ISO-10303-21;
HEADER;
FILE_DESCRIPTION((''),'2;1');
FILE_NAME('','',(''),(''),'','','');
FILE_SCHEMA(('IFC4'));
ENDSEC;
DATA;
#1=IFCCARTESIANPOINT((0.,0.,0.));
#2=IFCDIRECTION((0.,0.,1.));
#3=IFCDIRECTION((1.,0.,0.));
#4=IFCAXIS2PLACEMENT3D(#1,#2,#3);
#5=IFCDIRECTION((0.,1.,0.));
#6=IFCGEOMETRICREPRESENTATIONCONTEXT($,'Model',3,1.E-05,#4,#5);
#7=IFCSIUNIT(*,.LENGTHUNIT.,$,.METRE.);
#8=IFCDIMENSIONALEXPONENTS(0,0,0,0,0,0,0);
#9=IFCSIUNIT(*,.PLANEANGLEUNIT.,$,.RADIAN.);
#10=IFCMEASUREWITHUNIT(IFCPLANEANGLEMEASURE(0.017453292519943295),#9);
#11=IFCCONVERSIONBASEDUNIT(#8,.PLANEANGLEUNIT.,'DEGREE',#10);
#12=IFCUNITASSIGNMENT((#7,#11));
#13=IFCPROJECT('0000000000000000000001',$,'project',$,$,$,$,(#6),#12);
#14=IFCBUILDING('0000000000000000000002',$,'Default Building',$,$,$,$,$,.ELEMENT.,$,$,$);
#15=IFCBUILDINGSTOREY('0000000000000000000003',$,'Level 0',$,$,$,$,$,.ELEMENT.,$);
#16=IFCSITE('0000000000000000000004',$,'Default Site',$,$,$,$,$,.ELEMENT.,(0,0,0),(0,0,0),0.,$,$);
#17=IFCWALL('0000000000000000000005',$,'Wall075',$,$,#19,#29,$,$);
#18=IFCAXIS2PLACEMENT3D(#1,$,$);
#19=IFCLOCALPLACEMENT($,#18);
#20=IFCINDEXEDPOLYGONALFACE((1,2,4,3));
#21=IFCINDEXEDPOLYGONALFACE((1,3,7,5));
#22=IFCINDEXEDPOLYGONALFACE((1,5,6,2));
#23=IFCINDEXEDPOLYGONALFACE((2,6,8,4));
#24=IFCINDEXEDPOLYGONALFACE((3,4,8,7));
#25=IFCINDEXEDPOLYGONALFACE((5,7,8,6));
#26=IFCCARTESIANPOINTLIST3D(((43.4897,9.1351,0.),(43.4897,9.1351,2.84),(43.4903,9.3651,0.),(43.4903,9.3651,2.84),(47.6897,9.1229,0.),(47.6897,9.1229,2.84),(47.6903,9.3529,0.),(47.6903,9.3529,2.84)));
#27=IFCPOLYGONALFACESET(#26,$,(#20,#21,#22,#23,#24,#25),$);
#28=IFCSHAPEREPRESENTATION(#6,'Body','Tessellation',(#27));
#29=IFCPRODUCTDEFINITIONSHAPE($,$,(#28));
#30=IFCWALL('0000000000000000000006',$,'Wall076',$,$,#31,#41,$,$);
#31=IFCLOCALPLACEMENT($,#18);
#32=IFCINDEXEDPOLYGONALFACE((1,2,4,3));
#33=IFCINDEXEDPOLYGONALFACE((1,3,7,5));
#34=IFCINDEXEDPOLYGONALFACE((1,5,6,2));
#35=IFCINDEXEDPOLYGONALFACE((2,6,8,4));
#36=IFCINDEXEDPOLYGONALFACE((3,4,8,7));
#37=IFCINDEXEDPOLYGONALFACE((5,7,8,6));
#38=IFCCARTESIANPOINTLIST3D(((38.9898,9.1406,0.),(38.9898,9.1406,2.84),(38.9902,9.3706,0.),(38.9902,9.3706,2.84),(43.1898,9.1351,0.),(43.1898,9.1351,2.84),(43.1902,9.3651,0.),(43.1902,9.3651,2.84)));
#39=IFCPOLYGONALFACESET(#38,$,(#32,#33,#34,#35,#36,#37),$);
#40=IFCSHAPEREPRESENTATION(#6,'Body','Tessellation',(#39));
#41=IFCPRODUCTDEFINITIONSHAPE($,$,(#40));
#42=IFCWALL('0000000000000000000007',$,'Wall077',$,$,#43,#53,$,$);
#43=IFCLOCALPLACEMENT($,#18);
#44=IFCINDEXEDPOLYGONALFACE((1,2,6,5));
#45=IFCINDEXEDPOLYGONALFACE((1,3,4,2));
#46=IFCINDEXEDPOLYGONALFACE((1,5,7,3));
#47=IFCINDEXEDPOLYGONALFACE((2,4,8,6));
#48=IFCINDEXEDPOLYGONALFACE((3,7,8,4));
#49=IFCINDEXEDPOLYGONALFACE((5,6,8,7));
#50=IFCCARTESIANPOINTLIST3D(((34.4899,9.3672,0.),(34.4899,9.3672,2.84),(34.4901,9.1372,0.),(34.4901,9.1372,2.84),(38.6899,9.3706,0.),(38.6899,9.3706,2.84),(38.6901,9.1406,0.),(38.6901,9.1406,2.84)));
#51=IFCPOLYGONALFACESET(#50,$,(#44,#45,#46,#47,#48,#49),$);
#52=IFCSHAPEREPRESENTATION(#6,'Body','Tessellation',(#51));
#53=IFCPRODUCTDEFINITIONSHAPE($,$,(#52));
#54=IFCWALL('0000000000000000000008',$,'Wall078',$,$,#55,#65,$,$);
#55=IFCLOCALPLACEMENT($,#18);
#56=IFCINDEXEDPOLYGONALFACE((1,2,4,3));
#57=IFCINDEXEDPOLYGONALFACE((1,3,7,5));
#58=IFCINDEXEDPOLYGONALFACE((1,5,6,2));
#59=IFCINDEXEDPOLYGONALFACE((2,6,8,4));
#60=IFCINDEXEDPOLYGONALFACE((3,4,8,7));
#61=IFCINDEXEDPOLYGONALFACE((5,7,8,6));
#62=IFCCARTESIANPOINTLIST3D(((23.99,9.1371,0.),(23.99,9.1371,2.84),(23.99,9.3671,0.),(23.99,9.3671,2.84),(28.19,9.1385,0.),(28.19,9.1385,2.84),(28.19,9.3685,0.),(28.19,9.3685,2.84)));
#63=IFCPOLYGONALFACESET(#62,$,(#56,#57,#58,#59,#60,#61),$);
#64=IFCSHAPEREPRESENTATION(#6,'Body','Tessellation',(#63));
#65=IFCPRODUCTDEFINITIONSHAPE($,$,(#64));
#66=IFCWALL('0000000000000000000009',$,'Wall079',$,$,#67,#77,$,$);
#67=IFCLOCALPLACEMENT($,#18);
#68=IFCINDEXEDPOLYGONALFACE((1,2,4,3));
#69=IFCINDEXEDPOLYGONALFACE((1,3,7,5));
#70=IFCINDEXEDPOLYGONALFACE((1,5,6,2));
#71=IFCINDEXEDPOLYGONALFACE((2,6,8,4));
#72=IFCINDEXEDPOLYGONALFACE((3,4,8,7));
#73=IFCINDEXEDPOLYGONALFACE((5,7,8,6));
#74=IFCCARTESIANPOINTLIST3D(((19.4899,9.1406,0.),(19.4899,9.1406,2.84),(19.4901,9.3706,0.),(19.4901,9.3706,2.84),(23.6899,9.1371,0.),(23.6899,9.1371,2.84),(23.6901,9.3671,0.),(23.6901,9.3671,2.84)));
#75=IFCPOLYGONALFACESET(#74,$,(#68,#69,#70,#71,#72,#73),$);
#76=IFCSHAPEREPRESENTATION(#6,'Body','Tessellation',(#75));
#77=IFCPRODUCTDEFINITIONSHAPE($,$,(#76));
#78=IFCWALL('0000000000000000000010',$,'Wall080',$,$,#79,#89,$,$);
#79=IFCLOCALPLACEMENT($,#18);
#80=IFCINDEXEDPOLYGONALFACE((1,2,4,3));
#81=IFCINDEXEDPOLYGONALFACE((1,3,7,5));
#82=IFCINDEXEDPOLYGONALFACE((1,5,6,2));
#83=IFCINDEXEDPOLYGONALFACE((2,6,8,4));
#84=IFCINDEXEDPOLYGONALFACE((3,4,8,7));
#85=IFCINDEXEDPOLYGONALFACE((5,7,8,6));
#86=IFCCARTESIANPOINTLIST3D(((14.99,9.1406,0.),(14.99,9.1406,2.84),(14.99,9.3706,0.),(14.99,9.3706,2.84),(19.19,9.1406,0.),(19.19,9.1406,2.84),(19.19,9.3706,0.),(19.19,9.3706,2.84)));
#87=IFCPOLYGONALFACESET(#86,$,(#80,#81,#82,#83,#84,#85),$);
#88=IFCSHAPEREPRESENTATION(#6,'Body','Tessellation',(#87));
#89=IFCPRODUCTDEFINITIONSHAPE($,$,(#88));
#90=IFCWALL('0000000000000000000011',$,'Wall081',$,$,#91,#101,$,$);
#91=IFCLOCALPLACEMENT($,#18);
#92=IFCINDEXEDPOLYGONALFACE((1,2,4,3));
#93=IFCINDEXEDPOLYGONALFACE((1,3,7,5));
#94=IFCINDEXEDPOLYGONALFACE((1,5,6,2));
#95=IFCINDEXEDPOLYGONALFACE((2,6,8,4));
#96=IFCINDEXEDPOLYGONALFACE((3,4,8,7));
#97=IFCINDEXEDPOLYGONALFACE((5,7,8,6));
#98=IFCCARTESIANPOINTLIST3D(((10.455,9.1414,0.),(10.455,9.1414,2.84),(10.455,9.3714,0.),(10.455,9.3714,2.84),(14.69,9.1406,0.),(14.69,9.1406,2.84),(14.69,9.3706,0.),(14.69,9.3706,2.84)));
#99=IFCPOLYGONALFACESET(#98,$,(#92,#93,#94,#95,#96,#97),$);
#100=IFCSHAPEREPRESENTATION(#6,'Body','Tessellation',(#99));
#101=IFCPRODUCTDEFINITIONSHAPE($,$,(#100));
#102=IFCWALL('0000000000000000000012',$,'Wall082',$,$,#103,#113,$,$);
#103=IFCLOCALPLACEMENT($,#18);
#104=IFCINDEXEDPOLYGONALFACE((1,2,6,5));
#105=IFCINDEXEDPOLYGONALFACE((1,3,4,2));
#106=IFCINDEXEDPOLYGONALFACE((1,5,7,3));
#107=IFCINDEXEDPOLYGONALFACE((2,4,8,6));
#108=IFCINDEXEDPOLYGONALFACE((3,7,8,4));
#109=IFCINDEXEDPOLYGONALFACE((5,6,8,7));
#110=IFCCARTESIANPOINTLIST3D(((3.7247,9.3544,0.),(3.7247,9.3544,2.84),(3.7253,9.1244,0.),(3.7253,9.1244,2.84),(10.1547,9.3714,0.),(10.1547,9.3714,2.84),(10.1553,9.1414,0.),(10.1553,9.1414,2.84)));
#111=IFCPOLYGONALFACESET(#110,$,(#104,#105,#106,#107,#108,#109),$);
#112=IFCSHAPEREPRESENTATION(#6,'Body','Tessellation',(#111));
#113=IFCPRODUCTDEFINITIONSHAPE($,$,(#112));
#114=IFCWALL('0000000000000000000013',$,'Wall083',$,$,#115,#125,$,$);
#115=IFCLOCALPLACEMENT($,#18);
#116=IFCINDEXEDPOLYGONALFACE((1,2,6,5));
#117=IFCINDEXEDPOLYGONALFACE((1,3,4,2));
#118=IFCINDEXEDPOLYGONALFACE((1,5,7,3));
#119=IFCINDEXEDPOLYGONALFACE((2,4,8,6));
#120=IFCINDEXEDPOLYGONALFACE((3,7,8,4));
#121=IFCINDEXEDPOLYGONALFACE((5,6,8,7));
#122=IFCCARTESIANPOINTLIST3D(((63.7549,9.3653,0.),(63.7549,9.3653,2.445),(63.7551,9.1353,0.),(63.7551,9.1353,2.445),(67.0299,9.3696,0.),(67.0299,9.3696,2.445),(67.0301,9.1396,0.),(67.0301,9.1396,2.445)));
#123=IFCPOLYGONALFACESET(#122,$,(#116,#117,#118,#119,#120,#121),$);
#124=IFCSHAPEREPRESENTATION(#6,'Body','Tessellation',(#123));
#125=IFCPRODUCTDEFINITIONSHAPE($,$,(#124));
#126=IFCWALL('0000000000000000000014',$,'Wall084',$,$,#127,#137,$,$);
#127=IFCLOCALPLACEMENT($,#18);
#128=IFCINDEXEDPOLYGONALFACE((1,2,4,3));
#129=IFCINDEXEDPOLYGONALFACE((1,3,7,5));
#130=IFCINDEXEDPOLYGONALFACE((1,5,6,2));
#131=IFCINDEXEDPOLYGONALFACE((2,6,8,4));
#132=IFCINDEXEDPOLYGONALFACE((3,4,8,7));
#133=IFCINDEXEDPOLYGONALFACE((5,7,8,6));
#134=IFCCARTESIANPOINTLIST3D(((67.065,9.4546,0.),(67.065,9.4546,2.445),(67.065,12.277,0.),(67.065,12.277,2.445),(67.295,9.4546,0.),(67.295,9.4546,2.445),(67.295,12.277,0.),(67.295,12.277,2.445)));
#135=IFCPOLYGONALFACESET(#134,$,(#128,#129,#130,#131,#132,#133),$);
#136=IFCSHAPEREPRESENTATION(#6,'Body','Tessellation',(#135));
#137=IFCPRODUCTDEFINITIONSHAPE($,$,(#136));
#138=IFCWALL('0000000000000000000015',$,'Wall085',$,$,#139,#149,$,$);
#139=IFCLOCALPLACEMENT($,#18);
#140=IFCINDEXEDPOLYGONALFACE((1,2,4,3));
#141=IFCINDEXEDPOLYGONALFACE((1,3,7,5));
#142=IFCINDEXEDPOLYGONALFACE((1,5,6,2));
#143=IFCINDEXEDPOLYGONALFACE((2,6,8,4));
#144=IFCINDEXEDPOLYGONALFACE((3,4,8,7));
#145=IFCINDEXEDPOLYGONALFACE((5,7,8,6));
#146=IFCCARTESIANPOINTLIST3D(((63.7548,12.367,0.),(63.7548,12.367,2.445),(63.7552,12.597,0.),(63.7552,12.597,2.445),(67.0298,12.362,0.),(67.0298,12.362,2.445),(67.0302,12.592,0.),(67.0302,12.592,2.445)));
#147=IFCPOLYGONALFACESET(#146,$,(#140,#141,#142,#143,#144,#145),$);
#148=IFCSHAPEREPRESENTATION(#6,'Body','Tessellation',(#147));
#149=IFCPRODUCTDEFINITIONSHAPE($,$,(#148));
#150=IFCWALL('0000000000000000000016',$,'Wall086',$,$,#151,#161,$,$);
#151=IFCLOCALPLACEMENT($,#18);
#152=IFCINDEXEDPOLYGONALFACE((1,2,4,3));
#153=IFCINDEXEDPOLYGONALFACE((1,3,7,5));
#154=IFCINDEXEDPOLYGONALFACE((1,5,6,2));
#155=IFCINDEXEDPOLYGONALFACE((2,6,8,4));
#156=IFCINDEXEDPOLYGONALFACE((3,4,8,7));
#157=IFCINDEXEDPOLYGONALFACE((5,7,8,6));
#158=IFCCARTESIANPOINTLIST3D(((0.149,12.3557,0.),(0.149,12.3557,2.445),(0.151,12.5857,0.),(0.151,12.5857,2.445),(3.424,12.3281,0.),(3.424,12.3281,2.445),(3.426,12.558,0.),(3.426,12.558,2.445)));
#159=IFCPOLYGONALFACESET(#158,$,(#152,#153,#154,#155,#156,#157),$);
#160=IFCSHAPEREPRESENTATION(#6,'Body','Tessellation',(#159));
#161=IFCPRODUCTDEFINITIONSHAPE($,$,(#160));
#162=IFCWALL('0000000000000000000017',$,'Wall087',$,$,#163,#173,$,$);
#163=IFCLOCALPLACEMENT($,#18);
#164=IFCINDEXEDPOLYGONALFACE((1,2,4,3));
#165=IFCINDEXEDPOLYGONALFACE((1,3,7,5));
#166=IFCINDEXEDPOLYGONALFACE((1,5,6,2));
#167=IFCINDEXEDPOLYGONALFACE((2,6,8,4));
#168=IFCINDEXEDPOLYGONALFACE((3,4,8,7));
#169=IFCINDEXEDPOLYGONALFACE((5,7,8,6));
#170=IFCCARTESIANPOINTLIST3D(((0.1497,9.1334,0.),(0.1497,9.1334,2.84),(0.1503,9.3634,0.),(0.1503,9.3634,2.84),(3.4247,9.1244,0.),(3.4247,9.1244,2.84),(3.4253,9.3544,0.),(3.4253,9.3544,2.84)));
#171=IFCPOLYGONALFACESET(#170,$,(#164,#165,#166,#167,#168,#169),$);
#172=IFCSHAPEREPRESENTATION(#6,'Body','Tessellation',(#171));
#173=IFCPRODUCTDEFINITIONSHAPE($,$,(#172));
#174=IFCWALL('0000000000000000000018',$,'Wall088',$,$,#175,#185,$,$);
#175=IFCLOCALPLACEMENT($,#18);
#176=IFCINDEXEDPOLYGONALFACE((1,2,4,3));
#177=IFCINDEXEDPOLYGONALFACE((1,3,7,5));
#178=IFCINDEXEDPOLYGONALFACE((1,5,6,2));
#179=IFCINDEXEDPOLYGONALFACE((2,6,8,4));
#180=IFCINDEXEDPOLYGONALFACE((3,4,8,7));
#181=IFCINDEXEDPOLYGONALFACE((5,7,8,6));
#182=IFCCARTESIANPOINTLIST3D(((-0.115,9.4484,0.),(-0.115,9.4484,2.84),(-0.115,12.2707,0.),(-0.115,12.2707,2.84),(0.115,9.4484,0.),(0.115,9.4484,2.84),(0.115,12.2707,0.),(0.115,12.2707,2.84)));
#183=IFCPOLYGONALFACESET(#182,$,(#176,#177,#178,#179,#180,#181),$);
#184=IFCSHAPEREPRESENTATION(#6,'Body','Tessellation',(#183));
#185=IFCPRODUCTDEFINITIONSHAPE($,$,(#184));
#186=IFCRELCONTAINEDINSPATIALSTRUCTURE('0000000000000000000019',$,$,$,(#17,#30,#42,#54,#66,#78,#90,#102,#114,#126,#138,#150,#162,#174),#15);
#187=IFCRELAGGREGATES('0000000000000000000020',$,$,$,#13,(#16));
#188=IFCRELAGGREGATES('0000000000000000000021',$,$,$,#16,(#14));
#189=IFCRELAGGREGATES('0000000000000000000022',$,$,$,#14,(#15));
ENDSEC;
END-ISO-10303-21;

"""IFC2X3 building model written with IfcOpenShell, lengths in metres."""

from ifc_helpers import new_model, entity, si_unit, converted_unit, direction, frame, frame_2d, origin_with_axes, place, context, project, spatial, rectangle, extrude, element, save


model = new_model("IFC2X3")

# Units and contexts
model_context = context("Model", 3, precision=1e-05, world=origin_with_axes(), true_north=direction((0.0, 1.0, 0.0)))
ifc_project = project(units=[si_unit("LENGTHUNIT", "METRE"), converted_unit("PLANEANGLEUNIT", "DEGREE", entity("IfcPlaneAngleMeasure", 0.017453292519943295), si_unit("PLANEANGLEUNIT", "RADIAN"), dimensions=[0, 0, 0, 0, 0, 0, 0])], contexts=[model_context])

# Site, building, storey
site = spatial("IfcSite", under=ifc_project, Name="Default Site", CompositionType="ELEMENT", RefLatitude=(0, 0, 0), RefLongitude=(0, 0, 0), RefElevation=0.0)
building = spatial("IfcBuilding", under=site, Name="Default Building", CompositionType="ELEMENT")
storey = spatial("IfcBuildingStorey", under=building, Name="Level 0", CompositionType="ELEMENT")

# Walls
placement = place(None, origin_with_axes())
element("IfcWall", 1, at=placement, inside=storey, Name="Wall075", context=model_context, shape_type="SweptSolid", body=[
    extrude(rectangle(XDim=4.2, YDim=0.23, at=frame_2d((0.0, 0.0), x_axis=(0.999996, -0.002895, 0.0))), frame((45.59, 9.244, 0.0), z_axis=(0.0, 0.0, 1.0), x_axis=(1.0, 0.0, 0.0)), (0.0, 0.0, 1.0), 2.84),
])
element("IfcWall", 2, at=placement, inside=storey, Name="Wall076", context=model_context, shape_type="SweptSolid", body=[
    extrude(rectangle(XDim=4.2, YDim=0.23, at=frame_2d((0.0, 0.0), x_axis=(-0.999999, 0.001314, 0.0))), frame((41.09, 9.2528, 0.0), z_axis=(0.0, 0.0, 1.0), x_axis=(1.0, 0.0, 0.0)), (0.0, 0.0, 1.0), 2.84),
])
element("IfcWall", 3, at=placement, inside=storey, Name="Wall077", context=model_context, shape_type="SweptSolid", body=[
    extrude(rectangle(XDim=4.2, YDim=0.23, at=frame_2d((0.0, 0.0), x_axis=(1.0, 0.000801, 0.0))), frame((36.59, 9.2539, 0.0), z_axis=(0.0, 0.0, 1.0), x_axis=(1.0, 0.0, 0.0)), (0.0, 0.0, 1.0), 2.84),
])
element("IfcWall", 4, at=placement, inside=storey, Name="Wall078", context=model_context, shape_type="SweptSolid", body=[
    extrude(rectangle(XDim=4.2, YDim=0.23, at=frame_2d((0.0, 0.0), x_axis=(-1.0, -0.000329, 0.0))), frame((26.09, 9.2528, 0.0), z_axis=(0.0, 0.0, 1.0), x_axis=(1.0, 0.0, 0.0)), (0.0, 0.0, 1.0), 2.84),
])
element("IfcWall", 5, at=placement, inside=storey, Name="Wall079", context=model_context, shape_type="SweptSolid", body=[
    extrude(rectangle(XDim=4.2, YDim=0.23, at=frame_2d((0.0, 0.0), x_axis=(-1.0, 0.000835, 0.0))), frame((21.59, 9.2539, 0.0), z_axis=(0.0, 0.0, 1.0), x_axis=(1.0, 0.0, 0.0)), (0.0, 0.0, 1.0), 2.84),
])
element("IfcWall", 6, at=placement, inside=storey, Name="Wall080", context=model_context, shape_type="SweptSolid", body=[
    extrude(rectangle(XDim=4.2, YDim=0.23, at=frame_2d((0.0, 0.0), x_axis=(-1.0, -0.000014, 0.0))), frame((17.09, 9.2556, 0.0), z_axis=(0.0, 0.0, 1.0), x_axis=(1.0, 0.0, 0.0)), (0.0, 0.0, 1.0), 2.84),
])
element("IfcWall", 7, at=placement, inside=storey, Name="Wall081", context=model_context, shape_type="SweptSolid", body=[
    extrude(rectangle(XDim=4.235, YDim=0.23, at=frame_2d((0.0, 0.0), x_axis=(1.0, -0.000195, 0.0))), frame((12.5725, 9.256, 0.0), z_axis=(0.0, 0.0, 1.0), x_axis=(1.0, 0.0, 0.0)), (0.0, 0.0, 1.0), 2.84),
])
element("IfcWall", 8, at=placement, inside=storey, Name="Wall082", context=model_context, shape_type="SweptSolid", body=[
    extrude(rectangle(XDim=6.43, YDim=0.23, at=frame_2d((0.0, 0.0), x_axis=(-0.999997, -0.002639, 0.0))), frame((6.94, 9.2479, 0.0), z_axis=(0.0, 0.0, 1.0), x_axis=(1.0, 0.0, 0.0)), (0.0, 0.0, 1.0), 2.84),
])
element("IfcWall", 9, at=placement, inside=storey, Name="Wall083", context=model_context, shape_type="SweptSolid", body=[
    extrude(rectangle(XDim=3.275, YDim=0.23, at=frame_2d((0.0, 0.0), x_axis=(0.999999, 0.001297, 0.0))), frame((65.3925, 9.2525, 0.0), z_axis=(0.0, 0.0, 1.0), x_axis=(1.0, 0.0, 0.0)), (0.0, 0.0, 1.0), 2.445),
])
element("IfcWall", 10, at=placement, inside=storey, Name="Wall084", context=model_context, shape_type="SweptSolid", body=[
    extrude(rectangle(XDim=2.8224, YDim=0.23, at=frame_2d((0.0, 0.0), x_axis=(0.0, -1.0, 0.0))), frame((67.18, 10.8658, 0.0), z_axis=(0.0, 0.0, 1.0), x_axis=(1.0, 0.0, 0.0)), (0.0, 0.0, 1.0), 2.445),
])
element("IfcWall", 11, at=placement, inside=storey, Name="Wall085", context=model_context, shape_type="SweptSolid", body=[
    extrude(rectangle(XDim=3.275, YDim=0.23, at=frame_2d((0.0, 0.0), x_axis=(0.999999, -0.001506, 0.0))), frame((65.3925, 12.4795, 0.0), z_axis=(0.0, 0.0, 1.0), x_axis=(1.0, 0.0, 0.0)), (0.0, 0.0, 1.0), 2.445),
])
element("IfcWall", 12, at=placement, inside=storey, Name="Wall086", context=model_context, shape_type="SweptSolid", body=[
    extrude(rectangle(XDim=3.2751, YDim=0.23, at=frame_2d((0.0, 0.0), x_axis=(-0.999964, 0.008443, 0.0))), frame((1.7875, 12.4569, 0.0), z_axis=(0.0, 0.0, 1.0), x_axis=(1.0, 0.0, 0.0)), (0.0, 0.0, 1.0), 2.445),
])
element("IfcWall", 13, at=placement, inside=storey, Name="Wall087", context=model_context, shape_type="SweptSolid", body=[
    extrude(rectangle(XDim=3.275, YDim=0.23, at=frame_2d((0.0, 0.0), x_axis=(0.999996, -0.002728, 0.0))), frame((1.7875, 9.2439, 0.0), z_axis=(0.0, 0.0, 1.0), x_axis=(1.0, 0.0, 0.0)), (0.0, 0.0, 1.0), 2.84),
])
element("IfcWall", 14, at=placement, inside=storey, Name="Wall088", context=model_context, shape_type="SweptSolid", body=[
    extrude(rectangle(XDim=2.8223, YDim=0.23, at=frame_2d((0.0, 0.0), x_axis=(0.0, 1.0, 0.0))), frame((0.0, 10.8595, 0.0), z_axis=(0.0, 0.0, 1.0), x_axis=(1.0, 0.0, 0.0)), (0.0, 0.0, 1.0), 2.84),
])

save(model, "model.ifc")
